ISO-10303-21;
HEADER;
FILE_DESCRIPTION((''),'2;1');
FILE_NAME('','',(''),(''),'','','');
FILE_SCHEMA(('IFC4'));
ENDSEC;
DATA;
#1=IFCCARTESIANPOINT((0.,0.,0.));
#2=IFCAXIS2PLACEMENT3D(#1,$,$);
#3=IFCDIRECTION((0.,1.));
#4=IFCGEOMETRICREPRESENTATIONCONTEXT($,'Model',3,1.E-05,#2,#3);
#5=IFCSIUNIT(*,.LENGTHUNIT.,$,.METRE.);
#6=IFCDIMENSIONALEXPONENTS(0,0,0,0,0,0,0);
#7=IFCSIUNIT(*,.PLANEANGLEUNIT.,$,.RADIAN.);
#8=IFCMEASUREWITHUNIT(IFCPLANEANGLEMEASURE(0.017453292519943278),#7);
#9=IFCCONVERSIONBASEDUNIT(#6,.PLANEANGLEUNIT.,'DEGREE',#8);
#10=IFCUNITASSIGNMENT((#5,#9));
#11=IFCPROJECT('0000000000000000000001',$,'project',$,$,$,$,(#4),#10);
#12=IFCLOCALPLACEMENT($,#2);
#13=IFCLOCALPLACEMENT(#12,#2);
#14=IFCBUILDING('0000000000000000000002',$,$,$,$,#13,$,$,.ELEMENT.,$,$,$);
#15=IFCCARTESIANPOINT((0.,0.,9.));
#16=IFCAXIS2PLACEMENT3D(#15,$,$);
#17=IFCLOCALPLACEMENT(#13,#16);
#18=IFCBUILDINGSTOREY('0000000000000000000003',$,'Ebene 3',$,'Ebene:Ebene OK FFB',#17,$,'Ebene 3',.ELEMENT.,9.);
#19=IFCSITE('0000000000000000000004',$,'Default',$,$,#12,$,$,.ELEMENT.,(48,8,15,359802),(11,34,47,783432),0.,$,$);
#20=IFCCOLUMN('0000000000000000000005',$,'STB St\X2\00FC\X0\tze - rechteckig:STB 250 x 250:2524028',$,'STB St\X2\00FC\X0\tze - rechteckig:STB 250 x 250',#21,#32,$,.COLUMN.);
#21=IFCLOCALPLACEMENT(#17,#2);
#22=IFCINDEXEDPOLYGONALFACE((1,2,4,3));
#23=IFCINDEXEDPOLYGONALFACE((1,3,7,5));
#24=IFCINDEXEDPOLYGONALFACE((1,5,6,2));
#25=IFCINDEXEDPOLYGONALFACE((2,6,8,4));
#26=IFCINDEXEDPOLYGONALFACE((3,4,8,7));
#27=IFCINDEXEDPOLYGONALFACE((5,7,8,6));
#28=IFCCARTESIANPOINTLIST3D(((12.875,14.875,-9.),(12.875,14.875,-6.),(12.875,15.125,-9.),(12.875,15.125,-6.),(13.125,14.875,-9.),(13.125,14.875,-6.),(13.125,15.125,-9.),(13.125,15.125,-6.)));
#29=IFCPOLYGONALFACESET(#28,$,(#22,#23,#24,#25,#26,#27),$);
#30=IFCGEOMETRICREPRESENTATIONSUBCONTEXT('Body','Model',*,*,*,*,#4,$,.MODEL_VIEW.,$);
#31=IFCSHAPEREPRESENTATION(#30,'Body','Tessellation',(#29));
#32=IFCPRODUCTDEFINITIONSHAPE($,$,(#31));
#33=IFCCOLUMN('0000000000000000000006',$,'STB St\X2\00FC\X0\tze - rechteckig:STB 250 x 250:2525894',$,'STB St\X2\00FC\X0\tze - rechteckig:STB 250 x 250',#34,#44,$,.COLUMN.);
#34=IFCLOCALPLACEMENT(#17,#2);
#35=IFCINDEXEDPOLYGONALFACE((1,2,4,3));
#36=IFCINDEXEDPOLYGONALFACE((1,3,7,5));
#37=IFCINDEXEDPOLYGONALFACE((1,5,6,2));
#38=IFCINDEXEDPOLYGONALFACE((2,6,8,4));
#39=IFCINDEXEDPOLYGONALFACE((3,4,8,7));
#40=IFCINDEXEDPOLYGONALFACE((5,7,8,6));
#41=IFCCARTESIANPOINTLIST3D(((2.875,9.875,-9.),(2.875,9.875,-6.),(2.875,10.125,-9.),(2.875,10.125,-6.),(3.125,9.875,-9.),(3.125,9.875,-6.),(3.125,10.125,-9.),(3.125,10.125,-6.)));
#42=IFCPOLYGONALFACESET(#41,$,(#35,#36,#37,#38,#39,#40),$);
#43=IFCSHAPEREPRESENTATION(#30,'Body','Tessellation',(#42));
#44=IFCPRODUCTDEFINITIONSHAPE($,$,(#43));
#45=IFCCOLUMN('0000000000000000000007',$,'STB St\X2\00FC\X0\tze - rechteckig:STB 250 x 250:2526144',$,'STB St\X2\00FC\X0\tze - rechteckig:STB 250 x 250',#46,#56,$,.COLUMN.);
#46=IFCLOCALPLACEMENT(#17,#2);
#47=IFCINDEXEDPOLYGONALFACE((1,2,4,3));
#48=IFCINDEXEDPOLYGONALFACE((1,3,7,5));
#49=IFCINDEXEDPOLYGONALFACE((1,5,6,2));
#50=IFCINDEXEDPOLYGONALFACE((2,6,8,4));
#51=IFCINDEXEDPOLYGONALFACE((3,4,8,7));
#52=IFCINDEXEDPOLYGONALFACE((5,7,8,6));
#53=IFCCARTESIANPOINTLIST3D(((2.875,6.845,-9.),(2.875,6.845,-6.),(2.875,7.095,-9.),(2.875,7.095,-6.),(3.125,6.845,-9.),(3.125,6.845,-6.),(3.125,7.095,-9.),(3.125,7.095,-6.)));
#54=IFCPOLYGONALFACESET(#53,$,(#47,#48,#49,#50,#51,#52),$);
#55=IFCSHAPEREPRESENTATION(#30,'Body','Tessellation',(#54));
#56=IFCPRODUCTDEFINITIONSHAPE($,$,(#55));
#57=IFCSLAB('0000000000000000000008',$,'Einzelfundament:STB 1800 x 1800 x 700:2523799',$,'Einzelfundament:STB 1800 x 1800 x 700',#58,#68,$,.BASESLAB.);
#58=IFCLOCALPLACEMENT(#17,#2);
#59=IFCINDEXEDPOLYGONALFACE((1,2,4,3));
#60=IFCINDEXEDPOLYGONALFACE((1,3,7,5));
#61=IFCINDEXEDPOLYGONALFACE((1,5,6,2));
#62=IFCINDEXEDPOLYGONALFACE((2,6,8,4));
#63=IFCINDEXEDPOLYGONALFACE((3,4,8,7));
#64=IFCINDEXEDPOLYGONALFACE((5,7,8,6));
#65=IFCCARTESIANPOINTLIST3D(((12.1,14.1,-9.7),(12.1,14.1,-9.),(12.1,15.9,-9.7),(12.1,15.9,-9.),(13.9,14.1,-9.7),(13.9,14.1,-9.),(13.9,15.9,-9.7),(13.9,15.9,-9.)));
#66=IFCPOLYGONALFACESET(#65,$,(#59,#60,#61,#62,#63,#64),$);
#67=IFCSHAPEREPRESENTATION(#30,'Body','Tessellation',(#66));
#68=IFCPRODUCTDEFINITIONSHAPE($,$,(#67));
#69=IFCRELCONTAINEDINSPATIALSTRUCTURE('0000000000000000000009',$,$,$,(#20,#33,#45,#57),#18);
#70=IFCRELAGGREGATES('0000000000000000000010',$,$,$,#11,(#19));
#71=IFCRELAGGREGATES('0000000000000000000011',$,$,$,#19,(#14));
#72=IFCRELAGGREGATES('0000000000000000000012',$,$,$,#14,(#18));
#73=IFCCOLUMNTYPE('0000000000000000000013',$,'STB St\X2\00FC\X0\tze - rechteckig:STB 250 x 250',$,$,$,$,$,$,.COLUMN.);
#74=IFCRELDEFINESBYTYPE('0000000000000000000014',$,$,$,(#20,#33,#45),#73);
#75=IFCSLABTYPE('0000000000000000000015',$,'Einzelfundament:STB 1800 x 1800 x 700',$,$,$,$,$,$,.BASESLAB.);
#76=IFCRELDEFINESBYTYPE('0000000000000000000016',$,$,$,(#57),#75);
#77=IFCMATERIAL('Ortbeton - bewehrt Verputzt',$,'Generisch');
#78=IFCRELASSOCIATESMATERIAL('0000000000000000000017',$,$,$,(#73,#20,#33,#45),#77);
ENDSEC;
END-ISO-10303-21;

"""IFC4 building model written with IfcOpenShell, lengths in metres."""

from ifc_helpers import new_model, entity, si_unit, converted_unit, direction, frame, origin, place, context, subcontext, project, spatial, indexed_curve, outline, extrude, source, transform, mapped, material, type_object, type_shapes, element, save


model = new_model("IFC4")

# Units and contexts
model_context = context("Model", 3, precision=1e-05, world=origin(), true_north=direction((0.0, 1.0)))
body_context = subcontext(model_context, "Body", "Model", "MODEL_VIEW")
ifc_project = project(units=[si_unit("LENGTHUNIT", "METRE"), converted_unit("PLANEANGLEUNIT", "DEGREE", entity("IfcPlaneAngleMeasure", 0.017453292519943278), si_unit("PLANEANGLEUNIT", "RADIAN"), dimensions=[0, 0, 0, 0, 0, 0, 0])], contexts=[model_context])

# Site, building, storey
site_placement = place(None, origin())
site = spatial("IfcSite", under=ifc_project, at=site_placement, Name="Default", CompositionType="ELEMENT", RefLatitude=(48, 8, 15, 359802), RefLongitude=(11, 34, 47, 783432), RefElevation=0.0)
building_placement = place(site_placement, origin())
building = spatial("IfcBuilding", under=site, at=building_placement, CompositionType="ELEMENT")
storey_placement = place(building_placement, frame((0.0, 0.0, 9.0)))
storey = spatial("IfcBuildingStorey", under=building, at=storey_placement, Name="Ebene 3", ObjectType="Ebene:Ebene OK FFB", LongName="Ebene 3", CompositionType="ELEMENT", Elevation=9.0)

# Columns
ifc_material_1 = material(Name="Ortbeton - bewehrt Verputzt", Category="Generisch")
column_type = type_object("IfcColumnType", Name="STB Stütze - rechteckig:STB 250 x 250", PredefinedType="COLUMN", material=ifc_material_1)
shared_shape = source(origin(), body_context, "Body", "SweptSolid", [
    extrude(outline(indexed_curve([(-0.125, -0.125), (0.125, -0.125), (0.125, 0.125), (-0.125, 0.125), (-0.125, -0.125)], self_intersect=False)), frame((0.0, 0.0, 0.0), z_axis=(0.0, 0.0, 1.0), x_axis=(-1.0, 0.0, 0.0)), (0.0, 0.0, 1.0), 3.0),
])
type_shapes(column_type, [shared_shape])
for number, where, name in (
    (1, (13.0, 15.0, -9.0), "STB Stütze - rechteckig:STB 250 x 250:2524028"),
    (2, (3.0, 10.0, -9.0), "STB Stütze - rechteckig:STB 250 x 250:2525894"),
    (3, (3.0, 6.97, -9.0), "STB Stütze - rechteckig:STB 250 x 250:2526144"),
):
    element("IfcColumn", number, at=place(storey_placement, frame(where)), inside=storey, type_object=column_type, material=ifc_material_1, Name=name, ObjectType="STB Stütze - rechteckig:STB 250 x 250", PredefinedType="COLUMN", context=body_context, shape_type="MappedRepresentation", body=[
        mapped(shared_shape, transform((0.0, 0.0, 0.0), scale=1.0)),
    ])

# Slab
slab_type_1 = type_object("IfcSlabType", Name="Einzelfundament:STB 1800 x 1800 x 700", PredefinedType="BASESLAB")
slab_1_placement = place(storey_placement, origin())
element("IfcSlab", 4, at=slab_1_placement, inside=storey, type_object=slab_type_1, Name="Einzelfundament:STB 1800 x 1800 x 700:2523799", ObjectType="Einzelfundament:STB 1800 x 1800 x 700", PredefinedType="BASESLAB", context=body_context, shape_type="SweptSolid", body=[
    extrude(outline(indexed_curve([(-0.9, -0.9), (0.9, -0.9), (0.9, 0.9), (-0.9, 0.9), (-0.9, -0.9)], self_intersect=False)), frame((13.0, 15.0, -9.7), z_axis=(0.0, 0.0, 1.0), x_axis=(-1.0, 0.0, 0.0)), (0.0, 0.0, 1.0), 0.7),
])

save(model, "model.ifc")
